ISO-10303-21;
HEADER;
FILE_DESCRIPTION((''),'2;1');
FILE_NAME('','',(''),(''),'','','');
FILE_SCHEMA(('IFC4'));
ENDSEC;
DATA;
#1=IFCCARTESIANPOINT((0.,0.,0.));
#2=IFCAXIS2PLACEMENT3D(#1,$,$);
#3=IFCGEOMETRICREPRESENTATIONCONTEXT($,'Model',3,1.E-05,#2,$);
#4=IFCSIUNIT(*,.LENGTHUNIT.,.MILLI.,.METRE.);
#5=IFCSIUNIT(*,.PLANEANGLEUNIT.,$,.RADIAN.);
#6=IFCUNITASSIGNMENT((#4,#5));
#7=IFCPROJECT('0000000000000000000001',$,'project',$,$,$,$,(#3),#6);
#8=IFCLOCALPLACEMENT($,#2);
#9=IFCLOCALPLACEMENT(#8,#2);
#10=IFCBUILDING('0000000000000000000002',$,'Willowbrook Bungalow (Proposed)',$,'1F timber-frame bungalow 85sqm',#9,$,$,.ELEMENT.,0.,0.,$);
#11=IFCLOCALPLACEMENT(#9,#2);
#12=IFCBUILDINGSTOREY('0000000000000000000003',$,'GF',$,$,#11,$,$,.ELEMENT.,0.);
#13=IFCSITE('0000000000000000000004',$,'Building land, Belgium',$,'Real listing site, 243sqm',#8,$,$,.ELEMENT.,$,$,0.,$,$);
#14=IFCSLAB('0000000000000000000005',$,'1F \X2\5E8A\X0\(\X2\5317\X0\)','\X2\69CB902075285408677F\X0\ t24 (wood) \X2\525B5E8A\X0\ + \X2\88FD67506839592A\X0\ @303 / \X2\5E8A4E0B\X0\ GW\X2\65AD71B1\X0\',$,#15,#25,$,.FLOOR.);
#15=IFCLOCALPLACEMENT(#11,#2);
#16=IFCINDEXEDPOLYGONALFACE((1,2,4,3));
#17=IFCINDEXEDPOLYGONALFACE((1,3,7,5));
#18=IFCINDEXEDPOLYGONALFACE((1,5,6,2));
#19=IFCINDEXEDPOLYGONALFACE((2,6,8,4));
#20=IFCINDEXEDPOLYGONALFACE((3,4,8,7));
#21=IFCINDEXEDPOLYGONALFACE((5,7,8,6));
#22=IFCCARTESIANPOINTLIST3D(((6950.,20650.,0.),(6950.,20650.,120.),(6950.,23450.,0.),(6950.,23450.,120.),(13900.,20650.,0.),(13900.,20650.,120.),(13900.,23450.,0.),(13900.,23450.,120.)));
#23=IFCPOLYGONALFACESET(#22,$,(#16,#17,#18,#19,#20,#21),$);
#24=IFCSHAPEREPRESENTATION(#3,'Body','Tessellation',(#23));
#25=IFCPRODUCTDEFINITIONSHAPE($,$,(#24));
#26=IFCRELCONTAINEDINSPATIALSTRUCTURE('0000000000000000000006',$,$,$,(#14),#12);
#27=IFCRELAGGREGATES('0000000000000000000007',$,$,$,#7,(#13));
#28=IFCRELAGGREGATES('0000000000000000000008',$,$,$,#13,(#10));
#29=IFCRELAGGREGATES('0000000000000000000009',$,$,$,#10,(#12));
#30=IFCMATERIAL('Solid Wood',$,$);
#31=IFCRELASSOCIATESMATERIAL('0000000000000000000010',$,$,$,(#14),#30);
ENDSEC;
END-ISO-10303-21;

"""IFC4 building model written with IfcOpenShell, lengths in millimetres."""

from ifc_helpers import new_model, si_unit, frame, frame_2d, origin, place, context, project, spatial, rectangle, extrude, material, element, save


model = new_model("IFC4")

# Units and contexts
model_context = context("Model", 3, precision=1e-05, world=origin())
ifc_project = project(units=[si_unit("LENGTHUNIT", "METRE", prefix="MILLI"), si_unit("PLANEANGLEUNIT", "RADIAN")], contexts=[model_context])

# Site, building, storey
site_placement = place(None, origin())
site = spatial("IfcSite", under=ifc_project, at=site_placement, Name="Building land, Belgium", ObjectType="Real listing site, 243sqm", CompositionType="ELEMENT", RefElevation=0.0)
building_placement = place(site_placement, origin())
building = spatial("IfcBuilding", under=site, at=building_placement, Name="Willowbrook Bungalow (Proposed)", ObjectType="1F timber-frame bungalow 85sqm", CompositionType="ELEMENT", ElevationOfRefHeight=0.0, ElevationOfTerrain=0.0)
storey_placement = place(building_placement, origin())
storey = spatial("IfcBuildingStorey", under=building, at=storey_placement, Name="GF", CompositionType="ELEMENT", Elevation=0.0)

# Slab
ifc_material_1 = material(Name="Solid Wood")
slab_1_placement = place(storey_placement, frame((3475.0, 10325.0, 0.0)))
element("IfcSlab", 1, at=slab_1_placement, inside=storey, material=ifc_material_1, Name="1F 床(北)", Description="構造用合板 t24 (wood) 剛床 + 製材根太 @303 / 床下 GW断熱", PredefinedType="FLOOR", context=model_context, shape_type="SweptSolid", body=[
    extrude(rectangle(XDim=6950.0, YDim=2800.0, at=frame_2d((3475.0, 1400.0))), frame((3475.0, 10325.0, 0.0)), (0.0, 0.0, 1.0), 120.0),
])

save(model, "model.ifc")
